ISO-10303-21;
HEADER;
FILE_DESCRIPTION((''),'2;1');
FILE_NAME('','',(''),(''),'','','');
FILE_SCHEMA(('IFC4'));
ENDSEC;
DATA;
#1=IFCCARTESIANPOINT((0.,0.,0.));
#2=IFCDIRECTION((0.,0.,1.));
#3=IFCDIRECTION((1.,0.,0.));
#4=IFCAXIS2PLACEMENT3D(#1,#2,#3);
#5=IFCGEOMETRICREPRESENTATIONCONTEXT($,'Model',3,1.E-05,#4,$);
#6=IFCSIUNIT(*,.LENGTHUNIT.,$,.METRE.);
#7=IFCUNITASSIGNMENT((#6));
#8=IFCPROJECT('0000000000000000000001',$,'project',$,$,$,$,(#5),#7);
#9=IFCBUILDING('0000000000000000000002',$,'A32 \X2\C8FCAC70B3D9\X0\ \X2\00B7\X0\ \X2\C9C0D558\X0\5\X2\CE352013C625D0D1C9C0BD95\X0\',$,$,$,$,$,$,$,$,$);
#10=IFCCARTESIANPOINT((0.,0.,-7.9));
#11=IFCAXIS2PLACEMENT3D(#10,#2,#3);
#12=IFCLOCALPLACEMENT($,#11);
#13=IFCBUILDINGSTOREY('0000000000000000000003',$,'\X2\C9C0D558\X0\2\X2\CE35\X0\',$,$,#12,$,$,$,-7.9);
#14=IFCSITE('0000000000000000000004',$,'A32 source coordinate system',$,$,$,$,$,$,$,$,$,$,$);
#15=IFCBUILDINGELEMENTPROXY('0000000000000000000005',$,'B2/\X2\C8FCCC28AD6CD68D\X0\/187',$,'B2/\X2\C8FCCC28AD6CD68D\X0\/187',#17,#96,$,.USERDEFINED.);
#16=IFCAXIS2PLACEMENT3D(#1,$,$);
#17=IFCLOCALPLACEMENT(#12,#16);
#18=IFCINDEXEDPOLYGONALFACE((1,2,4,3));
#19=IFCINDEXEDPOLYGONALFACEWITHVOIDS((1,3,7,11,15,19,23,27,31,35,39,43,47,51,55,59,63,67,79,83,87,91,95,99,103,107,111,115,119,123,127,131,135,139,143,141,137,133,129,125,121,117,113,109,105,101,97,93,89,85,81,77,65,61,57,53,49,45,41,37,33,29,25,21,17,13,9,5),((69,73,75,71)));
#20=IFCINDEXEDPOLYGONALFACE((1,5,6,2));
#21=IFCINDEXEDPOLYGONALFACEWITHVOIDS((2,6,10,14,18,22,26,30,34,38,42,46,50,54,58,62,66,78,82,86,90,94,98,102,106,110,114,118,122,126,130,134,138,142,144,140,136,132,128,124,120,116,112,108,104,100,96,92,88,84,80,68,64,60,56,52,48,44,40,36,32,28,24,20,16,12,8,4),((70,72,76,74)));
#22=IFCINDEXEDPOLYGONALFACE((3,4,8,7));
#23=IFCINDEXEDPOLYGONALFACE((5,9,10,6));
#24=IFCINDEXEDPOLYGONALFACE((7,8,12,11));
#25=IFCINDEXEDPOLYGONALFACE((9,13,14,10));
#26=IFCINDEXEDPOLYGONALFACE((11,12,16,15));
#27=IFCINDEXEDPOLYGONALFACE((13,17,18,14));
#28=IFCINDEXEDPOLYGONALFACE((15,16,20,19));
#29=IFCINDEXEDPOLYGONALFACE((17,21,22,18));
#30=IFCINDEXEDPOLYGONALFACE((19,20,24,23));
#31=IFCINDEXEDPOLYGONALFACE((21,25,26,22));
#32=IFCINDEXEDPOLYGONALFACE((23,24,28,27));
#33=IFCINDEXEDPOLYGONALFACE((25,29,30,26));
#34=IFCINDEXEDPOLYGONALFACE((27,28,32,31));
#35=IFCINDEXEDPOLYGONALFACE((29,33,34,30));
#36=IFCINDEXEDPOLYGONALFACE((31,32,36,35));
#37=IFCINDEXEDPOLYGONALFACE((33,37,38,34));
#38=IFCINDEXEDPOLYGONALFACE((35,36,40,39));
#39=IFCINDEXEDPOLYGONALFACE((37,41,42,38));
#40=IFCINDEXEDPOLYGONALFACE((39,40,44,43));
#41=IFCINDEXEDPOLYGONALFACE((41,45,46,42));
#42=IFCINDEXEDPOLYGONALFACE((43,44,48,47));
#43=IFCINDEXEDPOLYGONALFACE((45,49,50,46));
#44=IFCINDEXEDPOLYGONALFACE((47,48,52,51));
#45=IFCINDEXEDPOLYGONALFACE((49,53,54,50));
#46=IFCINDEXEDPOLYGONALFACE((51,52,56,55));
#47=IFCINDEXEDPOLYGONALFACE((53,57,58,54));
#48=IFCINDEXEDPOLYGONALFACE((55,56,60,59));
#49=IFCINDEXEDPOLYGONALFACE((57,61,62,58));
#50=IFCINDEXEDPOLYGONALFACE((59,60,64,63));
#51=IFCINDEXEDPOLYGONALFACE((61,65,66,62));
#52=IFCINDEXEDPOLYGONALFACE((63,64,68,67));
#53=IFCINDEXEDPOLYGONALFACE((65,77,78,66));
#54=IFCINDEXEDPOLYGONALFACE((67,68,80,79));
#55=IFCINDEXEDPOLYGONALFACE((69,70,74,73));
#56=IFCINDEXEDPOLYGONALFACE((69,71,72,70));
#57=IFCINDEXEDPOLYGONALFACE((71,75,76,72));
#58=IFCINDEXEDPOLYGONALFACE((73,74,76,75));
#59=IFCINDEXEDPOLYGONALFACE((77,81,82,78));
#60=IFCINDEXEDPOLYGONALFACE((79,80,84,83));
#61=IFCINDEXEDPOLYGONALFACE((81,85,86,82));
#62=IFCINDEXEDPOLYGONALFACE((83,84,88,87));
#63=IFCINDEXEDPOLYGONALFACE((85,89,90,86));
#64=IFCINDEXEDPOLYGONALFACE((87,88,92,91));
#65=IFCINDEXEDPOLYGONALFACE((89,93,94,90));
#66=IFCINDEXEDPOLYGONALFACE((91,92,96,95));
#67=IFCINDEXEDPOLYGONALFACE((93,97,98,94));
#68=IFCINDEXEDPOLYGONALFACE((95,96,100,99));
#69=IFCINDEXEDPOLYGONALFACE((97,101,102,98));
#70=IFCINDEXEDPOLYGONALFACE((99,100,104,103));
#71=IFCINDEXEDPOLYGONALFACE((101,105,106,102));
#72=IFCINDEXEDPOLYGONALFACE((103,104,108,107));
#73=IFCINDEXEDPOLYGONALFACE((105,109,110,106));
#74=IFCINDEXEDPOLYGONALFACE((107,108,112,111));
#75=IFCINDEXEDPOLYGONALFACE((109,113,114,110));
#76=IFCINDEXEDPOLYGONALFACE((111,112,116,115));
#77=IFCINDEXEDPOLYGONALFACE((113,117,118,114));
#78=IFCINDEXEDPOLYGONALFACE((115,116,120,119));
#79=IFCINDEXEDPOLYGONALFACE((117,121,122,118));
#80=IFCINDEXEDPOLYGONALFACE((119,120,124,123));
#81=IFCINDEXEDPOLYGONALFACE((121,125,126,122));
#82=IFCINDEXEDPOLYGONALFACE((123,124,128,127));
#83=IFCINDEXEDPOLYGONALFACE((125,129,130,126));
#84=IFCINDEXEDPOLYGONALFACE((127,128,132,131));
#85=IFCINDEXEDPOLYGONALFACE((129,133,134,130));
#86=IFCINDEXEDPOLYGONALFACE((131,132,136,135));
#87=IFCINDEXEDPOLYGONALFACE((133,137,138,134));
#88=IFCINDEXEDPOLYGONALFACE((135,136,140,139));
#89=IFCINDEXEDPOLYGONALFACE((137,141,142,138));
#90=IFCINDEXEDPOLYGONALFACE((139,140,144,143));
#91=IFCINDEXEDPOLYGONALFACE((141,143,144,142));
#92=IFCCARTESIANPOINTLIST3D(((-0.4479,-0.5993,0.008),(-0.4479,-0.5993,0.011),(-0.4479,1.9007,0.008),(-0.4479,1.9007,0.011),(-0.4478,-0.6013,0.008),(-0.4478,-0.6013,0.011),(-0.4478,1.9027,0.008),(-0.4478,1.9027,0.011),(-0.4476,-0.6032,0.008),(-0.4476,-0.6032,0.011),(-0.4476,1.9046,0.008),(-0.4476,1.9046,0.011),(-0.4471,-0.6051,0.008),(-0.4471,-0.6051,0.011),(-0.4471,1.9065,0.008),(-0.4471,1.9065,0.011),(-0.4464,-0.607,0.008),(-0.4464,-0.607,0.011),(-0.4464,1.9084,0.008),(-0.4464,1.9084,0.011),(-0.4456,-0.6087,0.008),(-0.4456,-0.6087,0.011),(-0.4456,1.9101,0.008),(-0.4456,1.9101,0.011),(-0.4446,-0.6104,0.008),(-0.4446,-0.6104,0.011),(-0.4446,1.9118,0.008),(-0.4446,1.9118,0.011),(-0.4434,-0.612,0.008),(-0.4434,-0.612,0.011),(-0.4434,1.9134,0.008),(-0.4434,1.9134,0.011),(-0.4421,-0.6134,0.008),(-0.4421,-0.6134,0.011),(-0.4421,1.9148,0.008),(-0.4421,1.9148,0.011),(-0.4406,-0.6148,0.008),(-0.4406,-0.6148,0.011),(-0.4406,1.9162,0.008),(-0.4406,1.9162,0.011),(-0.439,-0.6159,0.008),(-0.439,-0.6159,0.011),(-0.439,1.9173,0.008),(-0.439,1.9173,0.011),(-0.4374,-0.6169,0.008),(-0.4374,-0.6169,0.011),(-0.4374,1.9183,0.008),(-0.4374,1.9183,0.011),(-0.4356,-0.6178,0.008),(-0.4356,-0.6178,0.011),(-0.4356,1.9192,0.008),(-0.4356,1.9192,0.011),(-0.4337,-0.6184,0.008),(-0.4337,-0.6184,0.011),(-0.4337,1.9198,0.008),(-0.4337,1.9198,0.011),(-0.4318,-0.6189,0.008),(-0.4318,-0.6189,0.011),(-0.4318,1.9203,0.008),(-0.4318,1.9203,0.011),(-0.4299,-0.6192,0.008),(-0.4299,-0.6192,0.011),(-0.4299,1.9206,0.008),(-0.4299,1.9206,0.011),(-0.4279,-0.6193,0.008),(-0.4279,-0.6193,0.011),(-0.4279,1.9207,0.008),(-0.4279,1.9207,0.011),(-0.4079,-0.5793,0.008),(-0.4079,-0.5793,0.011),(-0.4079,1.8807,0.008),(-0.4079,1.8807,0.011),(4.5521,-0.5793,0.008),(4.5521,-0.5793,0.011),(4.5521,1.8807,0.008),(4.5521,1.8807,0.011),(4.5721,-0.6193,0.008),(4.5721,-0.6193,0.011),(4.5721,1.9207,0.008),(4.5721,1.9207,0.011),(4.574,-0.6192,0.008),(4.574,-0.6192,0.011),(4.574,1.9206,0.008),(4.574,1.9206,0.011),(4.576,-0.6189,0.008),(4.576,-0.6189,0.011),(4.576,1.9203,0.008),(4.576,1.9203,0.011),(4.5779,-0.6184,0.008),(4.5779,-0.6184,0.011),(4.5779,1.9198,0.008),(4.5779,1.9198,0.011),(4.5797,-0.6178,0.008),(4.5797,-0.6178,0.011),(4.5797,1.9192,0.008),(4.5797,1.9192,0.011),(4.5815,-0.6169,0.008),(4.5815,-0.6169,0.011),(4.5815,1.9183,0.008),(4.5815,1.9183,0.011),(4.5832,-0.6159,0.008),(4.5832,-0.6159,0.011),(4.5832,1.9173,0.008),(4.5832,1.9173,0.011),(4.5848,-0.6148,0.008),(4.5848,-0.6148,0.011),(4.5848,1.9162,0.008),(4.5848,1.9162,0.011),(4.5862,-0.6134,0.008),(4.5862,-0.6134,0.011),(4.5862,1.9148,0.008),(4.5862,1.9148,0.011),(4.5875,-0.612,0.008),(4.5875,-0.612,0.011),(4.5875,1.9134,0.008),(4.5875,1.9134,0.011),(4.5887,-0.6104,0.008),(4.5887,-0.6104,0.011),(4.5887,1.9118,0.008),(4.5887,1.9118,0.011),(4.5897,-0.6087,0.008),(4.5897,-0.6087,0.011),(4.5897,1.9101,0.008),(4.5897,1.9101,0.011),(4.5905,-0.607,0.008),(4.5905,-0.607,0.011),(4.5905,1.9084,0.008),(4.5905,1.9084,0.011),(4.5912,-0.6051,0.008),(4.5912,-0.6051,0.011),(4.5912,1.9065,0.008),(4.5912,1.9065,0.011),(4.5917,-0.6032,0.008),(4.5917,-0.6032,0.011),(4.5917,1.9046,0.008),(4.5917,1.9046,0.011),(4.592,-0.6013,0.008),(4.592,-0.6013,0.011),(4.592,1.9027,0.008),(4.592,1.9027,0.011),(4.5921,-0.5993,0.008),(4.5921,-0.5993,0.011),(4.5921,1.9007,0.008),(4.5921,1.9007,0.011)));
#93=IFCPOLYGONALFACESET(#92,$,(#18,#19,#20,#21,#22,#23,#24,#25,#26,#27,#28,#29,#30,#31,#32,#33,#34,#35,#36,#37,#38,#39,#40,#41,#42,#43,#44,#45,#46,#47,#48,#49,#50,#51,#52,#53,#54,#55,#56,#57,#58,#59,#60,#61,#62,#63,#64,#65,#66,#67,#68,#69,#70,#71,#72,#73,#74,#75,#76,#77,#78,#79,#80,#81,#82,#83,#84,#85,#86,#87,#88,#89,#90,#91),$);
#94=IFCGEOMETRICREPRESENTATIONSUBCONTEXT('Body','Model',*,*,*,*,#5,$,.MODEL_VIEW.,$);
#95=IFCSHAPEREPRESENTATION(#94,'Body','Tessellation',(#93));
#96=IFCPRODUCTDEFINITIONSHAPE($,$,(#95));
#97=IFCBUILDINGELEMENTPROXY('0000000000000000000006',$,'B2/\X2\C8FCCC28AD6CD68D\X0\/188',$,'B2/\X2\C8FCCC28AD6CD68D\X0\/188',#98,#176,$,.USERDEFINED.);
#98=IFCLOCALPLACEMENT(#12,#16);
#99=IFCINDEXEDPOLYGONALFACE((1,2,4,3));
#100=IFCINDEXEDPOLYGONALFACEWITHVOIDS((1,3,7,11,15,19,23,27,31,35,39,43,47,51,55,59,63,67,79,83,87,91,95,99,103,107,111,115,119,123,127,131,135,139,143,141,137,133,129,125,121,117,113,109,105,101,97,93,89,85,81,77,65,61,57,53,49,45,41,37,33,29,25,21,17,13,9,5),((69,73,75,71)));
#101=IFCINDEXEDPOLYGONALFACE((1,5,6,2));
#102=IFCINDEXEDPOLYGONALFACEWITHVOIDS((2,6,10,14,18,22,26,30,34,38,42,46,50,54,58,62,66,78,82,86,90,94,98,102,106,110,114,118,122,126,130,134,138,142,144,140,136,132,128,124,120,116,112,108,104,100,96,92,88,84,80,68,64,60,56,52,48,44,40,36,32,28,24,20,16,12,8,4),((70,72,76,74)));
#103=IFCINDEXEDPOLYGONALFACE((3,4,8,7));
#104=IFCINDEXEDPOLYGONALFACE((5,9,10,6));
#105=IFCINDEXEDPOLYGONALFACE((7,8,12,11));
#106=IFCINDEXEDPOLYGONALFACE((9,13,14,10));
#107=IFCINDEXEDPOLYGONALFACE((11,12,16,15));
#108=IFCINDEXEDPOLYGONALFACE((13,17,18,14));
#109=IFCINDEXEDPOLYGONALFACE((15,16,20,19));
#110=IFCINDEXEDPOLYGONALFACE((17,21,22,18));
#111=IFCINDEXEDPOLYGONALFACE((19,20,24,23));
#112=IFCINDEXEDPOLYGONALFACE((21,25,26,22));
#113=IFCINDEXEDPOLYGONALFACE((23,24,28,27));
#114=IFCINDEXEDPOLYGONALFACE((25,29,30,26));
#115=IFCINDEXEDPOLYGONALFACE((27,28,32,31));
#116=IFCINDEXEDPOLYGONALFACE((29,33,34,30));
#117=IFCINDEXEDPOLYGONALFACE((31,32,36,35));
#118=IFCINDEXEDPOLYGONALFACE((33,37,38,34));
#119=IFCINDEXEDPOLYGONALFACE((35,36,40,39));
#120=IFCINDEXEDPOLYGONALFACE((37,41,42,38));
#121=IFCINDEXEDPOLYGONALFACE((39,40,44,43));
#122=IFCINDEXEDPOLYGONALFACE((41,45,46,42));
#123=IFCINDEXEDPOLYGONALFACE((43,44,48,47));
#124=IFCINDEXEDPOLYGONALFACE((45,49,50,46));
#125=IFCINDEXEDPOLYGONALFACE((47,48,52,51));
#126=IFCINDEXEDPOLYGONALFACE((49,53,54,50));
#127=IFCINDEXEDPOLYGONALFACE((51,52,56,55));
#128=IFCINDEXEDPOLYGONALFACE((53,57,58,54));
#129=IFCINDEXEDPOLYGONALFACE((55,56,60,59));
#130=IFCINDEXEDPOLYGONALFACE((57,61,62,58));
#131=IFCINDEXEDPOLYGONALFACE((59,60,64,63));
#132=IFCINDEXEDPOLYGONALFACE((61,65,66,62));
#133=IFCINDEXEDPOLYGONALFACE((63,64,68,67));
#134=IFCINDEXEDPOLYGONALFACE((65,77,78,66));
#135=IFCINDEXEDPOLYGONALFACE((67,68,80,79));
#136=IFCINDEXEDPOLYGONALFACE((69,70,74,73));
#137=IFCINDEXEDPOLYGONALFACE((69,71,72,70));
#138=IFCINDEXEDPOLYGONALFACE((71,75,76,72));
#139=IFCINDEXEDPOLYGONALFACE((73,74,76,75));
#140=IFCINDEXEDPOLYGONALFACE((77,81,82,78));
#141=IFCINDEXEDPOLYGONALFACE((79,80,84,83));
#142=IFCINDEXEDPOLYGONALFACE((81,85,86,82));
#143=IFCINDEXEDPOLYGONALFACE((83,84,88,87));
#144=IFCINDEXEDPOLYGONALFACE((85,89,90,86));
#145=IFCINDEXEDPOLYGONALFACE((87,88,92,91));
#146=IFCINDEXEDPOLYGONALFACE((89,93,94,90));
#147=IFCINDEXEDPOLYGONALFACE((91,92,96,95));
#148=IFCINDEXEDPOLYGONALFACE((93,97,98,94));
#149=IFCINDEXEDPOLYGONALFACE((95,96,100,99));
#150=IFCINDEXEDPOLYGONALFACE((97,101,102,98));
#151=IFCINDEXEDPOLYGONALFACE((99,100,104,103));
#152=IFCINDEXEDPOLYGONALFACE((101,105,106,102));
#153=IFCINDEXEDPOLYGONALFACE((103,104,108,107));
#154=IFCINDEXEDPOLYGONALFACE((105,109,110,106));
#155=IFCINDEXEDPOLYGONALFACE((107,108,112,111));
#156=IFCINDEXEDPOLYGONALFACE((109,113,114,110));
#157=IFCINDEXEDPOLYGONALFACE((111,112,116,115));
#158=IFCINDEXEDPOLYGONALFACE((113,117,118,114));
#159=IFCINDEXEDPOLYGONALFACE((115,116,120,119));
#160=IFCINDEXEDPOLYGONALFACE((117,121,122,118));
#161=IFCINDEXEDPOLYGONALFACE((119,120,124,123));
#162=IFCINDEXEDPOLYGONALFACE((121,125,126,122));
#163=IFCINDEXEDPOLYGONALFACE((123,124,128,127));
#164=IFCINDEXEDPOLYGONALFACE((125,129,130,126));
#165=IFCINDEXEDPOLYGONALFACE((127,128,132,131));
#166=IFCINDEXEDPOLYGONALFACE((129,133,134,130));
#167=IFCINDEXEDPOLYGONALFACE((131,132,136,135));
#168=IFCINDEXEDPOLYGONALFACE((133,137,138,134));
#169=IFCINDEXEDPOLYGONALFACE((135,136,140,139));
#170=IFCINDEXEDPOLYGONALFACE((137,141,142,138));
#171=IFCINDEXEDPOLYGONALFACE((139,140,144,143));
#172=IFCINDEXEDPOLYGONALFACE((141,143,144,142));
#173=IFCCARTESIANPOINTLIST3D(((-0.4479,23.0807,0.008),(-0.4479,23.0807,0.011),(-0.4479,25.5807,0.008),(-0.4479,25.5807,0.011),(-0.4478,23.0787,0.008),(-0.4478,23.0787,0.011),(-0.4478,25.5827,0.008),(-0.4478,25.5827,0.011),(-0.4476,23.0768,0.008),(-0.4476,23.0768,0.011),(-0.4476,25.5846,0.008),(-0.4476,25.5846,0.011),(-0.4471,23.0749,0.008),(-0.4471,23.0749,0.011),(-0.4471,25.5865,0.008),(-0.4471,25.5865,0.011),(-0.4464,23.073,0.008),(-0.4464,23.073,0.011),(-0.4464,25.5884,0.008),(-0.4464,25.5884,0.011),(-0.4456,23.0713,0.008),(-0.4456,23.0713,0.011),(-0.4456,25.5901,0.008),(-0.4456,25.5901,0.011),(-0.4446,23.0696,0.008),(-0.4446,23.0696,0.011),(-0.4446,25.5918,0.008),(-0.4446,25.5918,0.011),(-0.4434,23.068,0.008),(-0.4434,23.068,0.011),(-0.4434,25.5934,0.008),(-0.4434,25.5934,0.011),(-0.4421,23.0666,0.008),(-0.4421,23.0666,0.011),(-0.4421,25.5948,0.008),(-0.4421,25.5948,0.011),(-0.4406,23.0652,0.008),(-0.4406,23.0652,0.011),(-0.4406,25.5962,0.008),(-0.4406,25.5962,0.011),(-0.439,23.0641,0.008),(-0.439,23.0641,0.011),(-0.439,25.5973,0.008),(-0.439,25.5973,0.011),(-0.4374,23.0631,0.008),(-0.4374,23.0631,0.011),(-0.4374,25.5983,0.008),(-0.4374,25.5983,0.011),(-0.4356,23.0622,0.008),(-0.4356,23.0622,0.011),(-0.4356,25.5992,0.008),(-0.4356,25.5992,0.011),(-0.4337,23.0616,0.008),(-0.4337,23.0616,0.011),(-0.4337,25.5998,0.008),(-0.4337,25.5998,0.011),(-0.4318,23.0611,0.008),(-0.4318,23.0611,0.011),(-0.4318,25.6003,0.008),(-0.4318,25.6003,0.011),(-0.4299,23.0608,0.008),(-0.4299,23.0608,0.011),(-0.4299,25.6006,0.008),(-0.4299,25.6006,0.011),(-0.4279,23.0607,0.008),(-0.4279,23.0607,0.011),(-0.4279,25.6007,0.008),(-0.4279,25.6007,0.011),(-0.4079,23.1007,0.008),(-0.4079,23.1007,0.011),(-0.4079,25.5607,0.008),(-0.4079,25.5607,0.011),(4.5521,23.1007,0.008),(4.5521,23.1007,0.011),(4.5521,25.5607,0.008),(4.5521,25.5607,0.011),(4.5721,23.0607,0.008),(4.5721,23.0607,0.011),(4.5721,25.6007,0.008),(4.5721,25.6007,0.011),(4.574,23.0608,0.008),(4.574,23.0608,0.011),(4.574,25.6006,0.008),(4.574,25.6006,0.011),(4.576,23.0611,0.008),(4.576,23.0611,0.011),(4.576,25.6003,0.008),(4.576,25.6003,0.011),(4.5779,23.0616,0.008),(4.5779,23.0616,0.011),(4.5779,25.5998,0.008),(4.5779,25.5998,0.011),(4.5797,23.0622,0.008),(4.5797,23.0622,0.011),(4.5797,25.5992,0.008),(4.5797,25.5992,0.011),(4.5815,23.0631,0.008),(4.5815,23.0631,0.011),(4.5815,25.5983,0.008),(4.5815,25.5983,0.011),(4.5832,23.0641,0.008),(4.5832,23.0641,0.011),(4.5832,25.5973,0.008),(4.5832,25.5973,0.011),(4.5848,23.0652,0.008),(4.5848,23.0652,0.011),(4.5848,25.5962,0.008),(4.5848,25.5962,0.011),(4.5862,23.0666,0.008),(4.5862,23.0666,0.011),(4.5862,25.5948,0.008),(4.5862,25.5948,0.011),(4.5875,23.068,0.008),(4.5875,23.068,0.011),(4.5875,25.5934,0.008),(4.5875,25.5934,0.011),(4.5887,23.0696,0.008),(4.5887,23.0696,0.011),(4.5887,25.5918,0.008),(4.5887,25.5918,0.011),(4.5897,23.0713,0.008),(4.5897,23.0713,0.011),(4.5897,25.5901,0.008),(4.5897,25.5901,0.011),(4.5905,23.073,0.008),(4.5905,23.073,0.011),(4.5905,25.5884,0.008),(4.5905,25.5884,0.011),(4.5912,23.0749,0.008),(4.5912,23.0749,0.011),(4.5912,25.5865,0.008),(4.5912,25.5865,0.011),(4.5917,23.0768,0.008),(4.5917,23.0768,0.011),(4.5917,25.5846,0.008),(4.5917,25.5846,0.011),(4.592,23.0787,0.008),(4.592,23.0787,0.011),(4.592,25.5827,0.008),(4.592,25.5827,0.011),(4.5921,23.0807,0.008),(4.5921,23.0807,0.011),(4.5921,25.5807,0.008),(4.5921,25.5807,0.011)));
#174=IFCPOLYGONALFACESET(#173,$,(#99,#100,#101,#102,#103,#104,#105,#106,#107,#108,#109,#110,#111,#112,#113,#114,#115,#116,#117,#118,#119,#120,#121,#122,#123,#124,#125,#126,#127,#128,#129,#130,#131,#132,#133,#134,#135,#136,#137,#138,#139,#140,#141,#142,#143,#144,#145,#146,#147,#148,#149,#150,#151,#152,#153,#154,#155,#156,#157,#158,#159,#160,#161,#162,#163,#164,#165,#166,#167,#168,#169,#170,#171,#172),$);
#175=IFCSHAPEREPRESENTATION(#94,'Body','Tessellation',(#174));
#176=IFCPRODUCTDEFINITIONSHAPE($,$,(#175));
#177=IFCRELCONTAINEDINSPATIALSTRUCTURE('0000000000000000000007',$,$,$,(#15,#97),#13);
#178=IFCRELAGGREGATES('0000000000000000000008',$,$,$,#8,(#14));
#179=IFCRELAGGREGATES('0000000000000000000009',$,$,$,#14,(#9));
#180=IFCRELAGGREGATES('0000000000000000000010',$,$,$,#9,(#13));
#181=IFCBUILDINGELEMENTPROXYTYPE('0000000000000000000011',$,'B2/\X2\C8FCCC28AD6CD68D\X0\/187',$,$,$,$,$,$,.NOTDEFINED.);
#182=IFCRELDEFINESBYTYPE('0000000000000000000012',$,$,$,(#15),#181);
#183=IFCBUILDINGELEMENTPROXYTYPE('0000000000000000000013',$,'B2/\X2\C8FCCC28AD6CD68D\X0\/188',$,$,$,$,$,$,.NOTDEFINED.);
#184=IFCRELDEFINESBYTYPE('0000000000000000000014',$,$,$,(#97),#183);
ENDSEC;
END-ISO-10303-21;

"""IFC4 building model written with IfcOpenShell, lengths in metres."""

from ifc_helpers import new_model, si_unit, frame, origin, origin_with_axes, place, context, subcontext, project, spatial, polyline, outline, extrude, source, transform, mapped, type_object, type_shapes, element, save


model = new_model("IFC4")

# Units and contexts
model_context = context("Model", 3, precision=1e-05, world=origin_with_axes())
body_context = subcontext(model_context, "Body", "Model", "MODEL_VIEW")
ifc_project = project(units=[si_unit("LENGTHUNIT", "METRE")], contexts=[model_context])

# Site, building, storey
site = spatial("IfcSite", under=ifc_project, Name="A32 source coordinate system")
building = spatial("IfcBuilding", under=site, Name="A32 주거동 · 지하5층–옥탑지붕")
storey_placement = place(None, frame((0.0, 0.0, -7.9), z_axis=(0.0, 0.0, 1.0), x_axis=(1.0, 0.0, 0.0)))
storey = spatial("IfcBuildingStorey", under=building, at=storey_placement, Name="지하2층", Elevation=-7.9)

# Building element proxies
building_element_proxy_type_1 = type_object("IfcBuildingElementProxyType", Name="B2/주차구획/187", PredefinedType="NOTDEFINED")
shared_shape_1 = source(origin(), body_context, "Body", "SweptSolid", [
    extrude(outline(polyline([(-0.4279, -0.6193), (-0.4299, -0.6192), (-0.4318, -0.6189), (-0.4337, -0.6184), (-0.4356, -0.6178), (-0.4374, -0.6169), (-0.439, -0.6159), (-0.4406, -0.6148), (-0.4421, -0.6134), (-0.4434, -0.612), (-0.4446, -0.6104), (-0.4456, -0.6087), (-0.4464, -0.607), (-0.4471, -0.6051), (-0.4476, -0.6032), (-0.4478, -0.6013), (-0.4479, -0.5993), (-0.4479, 1.9007), (-0.4478, 1.9027), (-0.4476, 1.9046), (-0.4471, 1.9065), (-0.4464, 1.9084), (-0.4456, 1.9101), (-0.4446, 1.9118), (-0.4434, 1.9134), (-0.4421, 1.9148), (-0.4406, 1.9162), (-0.439, 1.9173), (-0.4374, 1.9183), (-0.4356, 1.9192), (-0.4337, 1.9198), (-0.4318, 1.9203), (-0.4299, 1.9206), (-0.4279, 1.9207), (4.5721, 1.9207), (4.574, 1.9206), (4.576, 1.9203), (4.5779, 1.9198), (4.5797, 1.9192), (4.5815, 1.9183), (4.5832, 1.9173), (4.5848, 1.9162), (4.5862, 1.9148), (4.5875, 1.9134), (4.5887, 1.9118), (4.5897, 1.9101), (4.5905, 1.9084), (4.5912, 1.9065), (4.5917, 1.9046), (4.592, 1.9027), (4.5921, 1.9007), (4.5921, -0.5993), (4.592, -0.6013), (4.5917, -0.6032), (4.5912, -0.6051), (4.5905, -0.607), (4.5897, -0.6087), (4.5887, -0.6104), (4.5875, -0.612), (4.5862, -0.6134), (4.5848, -0.6148), (4.5832, -0.6159), (4.5815, -0.6169), (4.5797, -0.6178), (4.5779, -0.6184), (4.576, -0.6189), (4.574, -0.6192), (4.5721, -0.6193), (-0.4279, -0.6193)]), holes=[polyline([(-0.4079, -0.5793), (4.5521, -0.5793), (4.5521, 1.8807), (-0.4079, 1.8807), (-0.4079, -0.5793)])]), frame((0.0, 0.0, 0.008)), (0.0, 0.0, 1.0), 0.003),
])
type_shapes(building_element_proxy_type_1, [shared_shape_1])
proxy_1_placement = place(storey_placement, origin_with_axes())
element("IfcBuildingElementProxy", 1, at=proxy_1_placement, inside=storey, type_object=building_element_proxy_type_1, Name="B2/주차구획/187", ObjectType="B2/주차구획/187", PredefinedType="USERDEFINED", context=body_context, shape_type="MappedRepresentation", body=[
    mapped(shared_shape_1, transform((0.0, 0.0, 0.0), scale=1.0)),
])
building_element_proxy_type_2 = type_object("IfcBuildingElementProxyType", Name="B2/주차구획/188", PredefinedType="NOTDEFINED")
shared_shape_2 = source(origin(), body_context, "Body", "SweptSolid", [
    extrude(outline(polyline([(-0.4279, 23.0607), (-0.4299, 23.0608), (-0.4318, 23.0611), (-0.4337, 23.0616), (-0.4356, 23.0622), (-0.4374, 23.0631), (-0.439, 23.0641), (-0.4406, 23.0652), (-0.4421, 23.0666), (-0.4434, 23.068), (-0.4446, 23.0696), (-0.4456, 23.0713), (-0.4464, 23.073), (-0.4471, 23.0749), (-0.4476, 23.0768), (-0.4478, 23.0787), (-0.4479, 23.0807), (-0.4479, 25.5807), (-0.4478, 25.5827), (-0.4476, 25.5846), (-0.4471, 25.5865), (-0.4464, 25.5884), (-0.4456, 25.5901), (-0.4446, 25.5918), (-0.4434, 25.5934), (-0.4421, 25.5948), (-0.4406, 25.5962), (-0.439, 25.5973), (-0.4374, 25.5983), (-0.4356, 25.5992), (-0.4337, 25.5998), (-0.4318, 25.6003), (-0.4299, 25.6006), (-0.4279, 25.6007), (4.5721, 25.6007), (4.574, 25.6006), (4.576, 25.6003), (4.5779, 25.5998), (4.5797, 25.5992), (4.5815, 25.5983), (4.5832, 25.5973), (4.5848, 25.5962), (4.5862, 25.5948), (4.5875, 25.5934), (4.5887, 25.5918), (4.5897, 25.5901), (4.5905, 25.5884), (4.5912, 25.5865), (4.5917, 25.5846), (4.592, 25.5827), (4.5921, 25.5807), (4.5921, 23.0807), (4.592, 23.0787), (4.5917, 23.0768), (4.5912, 23.0749), (4.5905, 23.073), (4.5897, 23.0713), (4.5887, 23.0696), (4.5875, 23.068), (4.5862, 23.0666), (4.5848, 23.0652), (4.5832, 23.0641), (4.5815, 23.0631), (4.5797, 23.0622), (4.5779, 23.0616), (4.576, 23.0611), (4.574, 23.0608), (4.5721, 23.0607), (-0.4279, 23.0607)]), holes=[polyline([(-0.4079, 23.1007), (4.5521, 23.1007), (4.5521, 25.5607), (-0.4079, 25.5607), (-0.4079, 23.1007)])]), frame((0.0, 0.0, 0.008)), (0.0, 0.0, 1.0), 0.003),
])
type_shapes(building_element_proxy_type_2, [shared_shape_2])
proxy_2_placement = place(storey_placement, origin_with_axes())
element("IfcBuildingElementProxy", 2, at=proxy_2_placement, inside=storey, type_object=building_element_proxy_type_2, Name="B2/주차구획/188", ObjectType="B2/주차구획/188", PredefinedType="USERDEFINED", context=body_context, shape_type="MappedRepresentation", body=[
    mapped(shared_shape_2, transform((0.0, 0.0, 0.0), scale=1.0)),
])

save(model, "model.ifc")
